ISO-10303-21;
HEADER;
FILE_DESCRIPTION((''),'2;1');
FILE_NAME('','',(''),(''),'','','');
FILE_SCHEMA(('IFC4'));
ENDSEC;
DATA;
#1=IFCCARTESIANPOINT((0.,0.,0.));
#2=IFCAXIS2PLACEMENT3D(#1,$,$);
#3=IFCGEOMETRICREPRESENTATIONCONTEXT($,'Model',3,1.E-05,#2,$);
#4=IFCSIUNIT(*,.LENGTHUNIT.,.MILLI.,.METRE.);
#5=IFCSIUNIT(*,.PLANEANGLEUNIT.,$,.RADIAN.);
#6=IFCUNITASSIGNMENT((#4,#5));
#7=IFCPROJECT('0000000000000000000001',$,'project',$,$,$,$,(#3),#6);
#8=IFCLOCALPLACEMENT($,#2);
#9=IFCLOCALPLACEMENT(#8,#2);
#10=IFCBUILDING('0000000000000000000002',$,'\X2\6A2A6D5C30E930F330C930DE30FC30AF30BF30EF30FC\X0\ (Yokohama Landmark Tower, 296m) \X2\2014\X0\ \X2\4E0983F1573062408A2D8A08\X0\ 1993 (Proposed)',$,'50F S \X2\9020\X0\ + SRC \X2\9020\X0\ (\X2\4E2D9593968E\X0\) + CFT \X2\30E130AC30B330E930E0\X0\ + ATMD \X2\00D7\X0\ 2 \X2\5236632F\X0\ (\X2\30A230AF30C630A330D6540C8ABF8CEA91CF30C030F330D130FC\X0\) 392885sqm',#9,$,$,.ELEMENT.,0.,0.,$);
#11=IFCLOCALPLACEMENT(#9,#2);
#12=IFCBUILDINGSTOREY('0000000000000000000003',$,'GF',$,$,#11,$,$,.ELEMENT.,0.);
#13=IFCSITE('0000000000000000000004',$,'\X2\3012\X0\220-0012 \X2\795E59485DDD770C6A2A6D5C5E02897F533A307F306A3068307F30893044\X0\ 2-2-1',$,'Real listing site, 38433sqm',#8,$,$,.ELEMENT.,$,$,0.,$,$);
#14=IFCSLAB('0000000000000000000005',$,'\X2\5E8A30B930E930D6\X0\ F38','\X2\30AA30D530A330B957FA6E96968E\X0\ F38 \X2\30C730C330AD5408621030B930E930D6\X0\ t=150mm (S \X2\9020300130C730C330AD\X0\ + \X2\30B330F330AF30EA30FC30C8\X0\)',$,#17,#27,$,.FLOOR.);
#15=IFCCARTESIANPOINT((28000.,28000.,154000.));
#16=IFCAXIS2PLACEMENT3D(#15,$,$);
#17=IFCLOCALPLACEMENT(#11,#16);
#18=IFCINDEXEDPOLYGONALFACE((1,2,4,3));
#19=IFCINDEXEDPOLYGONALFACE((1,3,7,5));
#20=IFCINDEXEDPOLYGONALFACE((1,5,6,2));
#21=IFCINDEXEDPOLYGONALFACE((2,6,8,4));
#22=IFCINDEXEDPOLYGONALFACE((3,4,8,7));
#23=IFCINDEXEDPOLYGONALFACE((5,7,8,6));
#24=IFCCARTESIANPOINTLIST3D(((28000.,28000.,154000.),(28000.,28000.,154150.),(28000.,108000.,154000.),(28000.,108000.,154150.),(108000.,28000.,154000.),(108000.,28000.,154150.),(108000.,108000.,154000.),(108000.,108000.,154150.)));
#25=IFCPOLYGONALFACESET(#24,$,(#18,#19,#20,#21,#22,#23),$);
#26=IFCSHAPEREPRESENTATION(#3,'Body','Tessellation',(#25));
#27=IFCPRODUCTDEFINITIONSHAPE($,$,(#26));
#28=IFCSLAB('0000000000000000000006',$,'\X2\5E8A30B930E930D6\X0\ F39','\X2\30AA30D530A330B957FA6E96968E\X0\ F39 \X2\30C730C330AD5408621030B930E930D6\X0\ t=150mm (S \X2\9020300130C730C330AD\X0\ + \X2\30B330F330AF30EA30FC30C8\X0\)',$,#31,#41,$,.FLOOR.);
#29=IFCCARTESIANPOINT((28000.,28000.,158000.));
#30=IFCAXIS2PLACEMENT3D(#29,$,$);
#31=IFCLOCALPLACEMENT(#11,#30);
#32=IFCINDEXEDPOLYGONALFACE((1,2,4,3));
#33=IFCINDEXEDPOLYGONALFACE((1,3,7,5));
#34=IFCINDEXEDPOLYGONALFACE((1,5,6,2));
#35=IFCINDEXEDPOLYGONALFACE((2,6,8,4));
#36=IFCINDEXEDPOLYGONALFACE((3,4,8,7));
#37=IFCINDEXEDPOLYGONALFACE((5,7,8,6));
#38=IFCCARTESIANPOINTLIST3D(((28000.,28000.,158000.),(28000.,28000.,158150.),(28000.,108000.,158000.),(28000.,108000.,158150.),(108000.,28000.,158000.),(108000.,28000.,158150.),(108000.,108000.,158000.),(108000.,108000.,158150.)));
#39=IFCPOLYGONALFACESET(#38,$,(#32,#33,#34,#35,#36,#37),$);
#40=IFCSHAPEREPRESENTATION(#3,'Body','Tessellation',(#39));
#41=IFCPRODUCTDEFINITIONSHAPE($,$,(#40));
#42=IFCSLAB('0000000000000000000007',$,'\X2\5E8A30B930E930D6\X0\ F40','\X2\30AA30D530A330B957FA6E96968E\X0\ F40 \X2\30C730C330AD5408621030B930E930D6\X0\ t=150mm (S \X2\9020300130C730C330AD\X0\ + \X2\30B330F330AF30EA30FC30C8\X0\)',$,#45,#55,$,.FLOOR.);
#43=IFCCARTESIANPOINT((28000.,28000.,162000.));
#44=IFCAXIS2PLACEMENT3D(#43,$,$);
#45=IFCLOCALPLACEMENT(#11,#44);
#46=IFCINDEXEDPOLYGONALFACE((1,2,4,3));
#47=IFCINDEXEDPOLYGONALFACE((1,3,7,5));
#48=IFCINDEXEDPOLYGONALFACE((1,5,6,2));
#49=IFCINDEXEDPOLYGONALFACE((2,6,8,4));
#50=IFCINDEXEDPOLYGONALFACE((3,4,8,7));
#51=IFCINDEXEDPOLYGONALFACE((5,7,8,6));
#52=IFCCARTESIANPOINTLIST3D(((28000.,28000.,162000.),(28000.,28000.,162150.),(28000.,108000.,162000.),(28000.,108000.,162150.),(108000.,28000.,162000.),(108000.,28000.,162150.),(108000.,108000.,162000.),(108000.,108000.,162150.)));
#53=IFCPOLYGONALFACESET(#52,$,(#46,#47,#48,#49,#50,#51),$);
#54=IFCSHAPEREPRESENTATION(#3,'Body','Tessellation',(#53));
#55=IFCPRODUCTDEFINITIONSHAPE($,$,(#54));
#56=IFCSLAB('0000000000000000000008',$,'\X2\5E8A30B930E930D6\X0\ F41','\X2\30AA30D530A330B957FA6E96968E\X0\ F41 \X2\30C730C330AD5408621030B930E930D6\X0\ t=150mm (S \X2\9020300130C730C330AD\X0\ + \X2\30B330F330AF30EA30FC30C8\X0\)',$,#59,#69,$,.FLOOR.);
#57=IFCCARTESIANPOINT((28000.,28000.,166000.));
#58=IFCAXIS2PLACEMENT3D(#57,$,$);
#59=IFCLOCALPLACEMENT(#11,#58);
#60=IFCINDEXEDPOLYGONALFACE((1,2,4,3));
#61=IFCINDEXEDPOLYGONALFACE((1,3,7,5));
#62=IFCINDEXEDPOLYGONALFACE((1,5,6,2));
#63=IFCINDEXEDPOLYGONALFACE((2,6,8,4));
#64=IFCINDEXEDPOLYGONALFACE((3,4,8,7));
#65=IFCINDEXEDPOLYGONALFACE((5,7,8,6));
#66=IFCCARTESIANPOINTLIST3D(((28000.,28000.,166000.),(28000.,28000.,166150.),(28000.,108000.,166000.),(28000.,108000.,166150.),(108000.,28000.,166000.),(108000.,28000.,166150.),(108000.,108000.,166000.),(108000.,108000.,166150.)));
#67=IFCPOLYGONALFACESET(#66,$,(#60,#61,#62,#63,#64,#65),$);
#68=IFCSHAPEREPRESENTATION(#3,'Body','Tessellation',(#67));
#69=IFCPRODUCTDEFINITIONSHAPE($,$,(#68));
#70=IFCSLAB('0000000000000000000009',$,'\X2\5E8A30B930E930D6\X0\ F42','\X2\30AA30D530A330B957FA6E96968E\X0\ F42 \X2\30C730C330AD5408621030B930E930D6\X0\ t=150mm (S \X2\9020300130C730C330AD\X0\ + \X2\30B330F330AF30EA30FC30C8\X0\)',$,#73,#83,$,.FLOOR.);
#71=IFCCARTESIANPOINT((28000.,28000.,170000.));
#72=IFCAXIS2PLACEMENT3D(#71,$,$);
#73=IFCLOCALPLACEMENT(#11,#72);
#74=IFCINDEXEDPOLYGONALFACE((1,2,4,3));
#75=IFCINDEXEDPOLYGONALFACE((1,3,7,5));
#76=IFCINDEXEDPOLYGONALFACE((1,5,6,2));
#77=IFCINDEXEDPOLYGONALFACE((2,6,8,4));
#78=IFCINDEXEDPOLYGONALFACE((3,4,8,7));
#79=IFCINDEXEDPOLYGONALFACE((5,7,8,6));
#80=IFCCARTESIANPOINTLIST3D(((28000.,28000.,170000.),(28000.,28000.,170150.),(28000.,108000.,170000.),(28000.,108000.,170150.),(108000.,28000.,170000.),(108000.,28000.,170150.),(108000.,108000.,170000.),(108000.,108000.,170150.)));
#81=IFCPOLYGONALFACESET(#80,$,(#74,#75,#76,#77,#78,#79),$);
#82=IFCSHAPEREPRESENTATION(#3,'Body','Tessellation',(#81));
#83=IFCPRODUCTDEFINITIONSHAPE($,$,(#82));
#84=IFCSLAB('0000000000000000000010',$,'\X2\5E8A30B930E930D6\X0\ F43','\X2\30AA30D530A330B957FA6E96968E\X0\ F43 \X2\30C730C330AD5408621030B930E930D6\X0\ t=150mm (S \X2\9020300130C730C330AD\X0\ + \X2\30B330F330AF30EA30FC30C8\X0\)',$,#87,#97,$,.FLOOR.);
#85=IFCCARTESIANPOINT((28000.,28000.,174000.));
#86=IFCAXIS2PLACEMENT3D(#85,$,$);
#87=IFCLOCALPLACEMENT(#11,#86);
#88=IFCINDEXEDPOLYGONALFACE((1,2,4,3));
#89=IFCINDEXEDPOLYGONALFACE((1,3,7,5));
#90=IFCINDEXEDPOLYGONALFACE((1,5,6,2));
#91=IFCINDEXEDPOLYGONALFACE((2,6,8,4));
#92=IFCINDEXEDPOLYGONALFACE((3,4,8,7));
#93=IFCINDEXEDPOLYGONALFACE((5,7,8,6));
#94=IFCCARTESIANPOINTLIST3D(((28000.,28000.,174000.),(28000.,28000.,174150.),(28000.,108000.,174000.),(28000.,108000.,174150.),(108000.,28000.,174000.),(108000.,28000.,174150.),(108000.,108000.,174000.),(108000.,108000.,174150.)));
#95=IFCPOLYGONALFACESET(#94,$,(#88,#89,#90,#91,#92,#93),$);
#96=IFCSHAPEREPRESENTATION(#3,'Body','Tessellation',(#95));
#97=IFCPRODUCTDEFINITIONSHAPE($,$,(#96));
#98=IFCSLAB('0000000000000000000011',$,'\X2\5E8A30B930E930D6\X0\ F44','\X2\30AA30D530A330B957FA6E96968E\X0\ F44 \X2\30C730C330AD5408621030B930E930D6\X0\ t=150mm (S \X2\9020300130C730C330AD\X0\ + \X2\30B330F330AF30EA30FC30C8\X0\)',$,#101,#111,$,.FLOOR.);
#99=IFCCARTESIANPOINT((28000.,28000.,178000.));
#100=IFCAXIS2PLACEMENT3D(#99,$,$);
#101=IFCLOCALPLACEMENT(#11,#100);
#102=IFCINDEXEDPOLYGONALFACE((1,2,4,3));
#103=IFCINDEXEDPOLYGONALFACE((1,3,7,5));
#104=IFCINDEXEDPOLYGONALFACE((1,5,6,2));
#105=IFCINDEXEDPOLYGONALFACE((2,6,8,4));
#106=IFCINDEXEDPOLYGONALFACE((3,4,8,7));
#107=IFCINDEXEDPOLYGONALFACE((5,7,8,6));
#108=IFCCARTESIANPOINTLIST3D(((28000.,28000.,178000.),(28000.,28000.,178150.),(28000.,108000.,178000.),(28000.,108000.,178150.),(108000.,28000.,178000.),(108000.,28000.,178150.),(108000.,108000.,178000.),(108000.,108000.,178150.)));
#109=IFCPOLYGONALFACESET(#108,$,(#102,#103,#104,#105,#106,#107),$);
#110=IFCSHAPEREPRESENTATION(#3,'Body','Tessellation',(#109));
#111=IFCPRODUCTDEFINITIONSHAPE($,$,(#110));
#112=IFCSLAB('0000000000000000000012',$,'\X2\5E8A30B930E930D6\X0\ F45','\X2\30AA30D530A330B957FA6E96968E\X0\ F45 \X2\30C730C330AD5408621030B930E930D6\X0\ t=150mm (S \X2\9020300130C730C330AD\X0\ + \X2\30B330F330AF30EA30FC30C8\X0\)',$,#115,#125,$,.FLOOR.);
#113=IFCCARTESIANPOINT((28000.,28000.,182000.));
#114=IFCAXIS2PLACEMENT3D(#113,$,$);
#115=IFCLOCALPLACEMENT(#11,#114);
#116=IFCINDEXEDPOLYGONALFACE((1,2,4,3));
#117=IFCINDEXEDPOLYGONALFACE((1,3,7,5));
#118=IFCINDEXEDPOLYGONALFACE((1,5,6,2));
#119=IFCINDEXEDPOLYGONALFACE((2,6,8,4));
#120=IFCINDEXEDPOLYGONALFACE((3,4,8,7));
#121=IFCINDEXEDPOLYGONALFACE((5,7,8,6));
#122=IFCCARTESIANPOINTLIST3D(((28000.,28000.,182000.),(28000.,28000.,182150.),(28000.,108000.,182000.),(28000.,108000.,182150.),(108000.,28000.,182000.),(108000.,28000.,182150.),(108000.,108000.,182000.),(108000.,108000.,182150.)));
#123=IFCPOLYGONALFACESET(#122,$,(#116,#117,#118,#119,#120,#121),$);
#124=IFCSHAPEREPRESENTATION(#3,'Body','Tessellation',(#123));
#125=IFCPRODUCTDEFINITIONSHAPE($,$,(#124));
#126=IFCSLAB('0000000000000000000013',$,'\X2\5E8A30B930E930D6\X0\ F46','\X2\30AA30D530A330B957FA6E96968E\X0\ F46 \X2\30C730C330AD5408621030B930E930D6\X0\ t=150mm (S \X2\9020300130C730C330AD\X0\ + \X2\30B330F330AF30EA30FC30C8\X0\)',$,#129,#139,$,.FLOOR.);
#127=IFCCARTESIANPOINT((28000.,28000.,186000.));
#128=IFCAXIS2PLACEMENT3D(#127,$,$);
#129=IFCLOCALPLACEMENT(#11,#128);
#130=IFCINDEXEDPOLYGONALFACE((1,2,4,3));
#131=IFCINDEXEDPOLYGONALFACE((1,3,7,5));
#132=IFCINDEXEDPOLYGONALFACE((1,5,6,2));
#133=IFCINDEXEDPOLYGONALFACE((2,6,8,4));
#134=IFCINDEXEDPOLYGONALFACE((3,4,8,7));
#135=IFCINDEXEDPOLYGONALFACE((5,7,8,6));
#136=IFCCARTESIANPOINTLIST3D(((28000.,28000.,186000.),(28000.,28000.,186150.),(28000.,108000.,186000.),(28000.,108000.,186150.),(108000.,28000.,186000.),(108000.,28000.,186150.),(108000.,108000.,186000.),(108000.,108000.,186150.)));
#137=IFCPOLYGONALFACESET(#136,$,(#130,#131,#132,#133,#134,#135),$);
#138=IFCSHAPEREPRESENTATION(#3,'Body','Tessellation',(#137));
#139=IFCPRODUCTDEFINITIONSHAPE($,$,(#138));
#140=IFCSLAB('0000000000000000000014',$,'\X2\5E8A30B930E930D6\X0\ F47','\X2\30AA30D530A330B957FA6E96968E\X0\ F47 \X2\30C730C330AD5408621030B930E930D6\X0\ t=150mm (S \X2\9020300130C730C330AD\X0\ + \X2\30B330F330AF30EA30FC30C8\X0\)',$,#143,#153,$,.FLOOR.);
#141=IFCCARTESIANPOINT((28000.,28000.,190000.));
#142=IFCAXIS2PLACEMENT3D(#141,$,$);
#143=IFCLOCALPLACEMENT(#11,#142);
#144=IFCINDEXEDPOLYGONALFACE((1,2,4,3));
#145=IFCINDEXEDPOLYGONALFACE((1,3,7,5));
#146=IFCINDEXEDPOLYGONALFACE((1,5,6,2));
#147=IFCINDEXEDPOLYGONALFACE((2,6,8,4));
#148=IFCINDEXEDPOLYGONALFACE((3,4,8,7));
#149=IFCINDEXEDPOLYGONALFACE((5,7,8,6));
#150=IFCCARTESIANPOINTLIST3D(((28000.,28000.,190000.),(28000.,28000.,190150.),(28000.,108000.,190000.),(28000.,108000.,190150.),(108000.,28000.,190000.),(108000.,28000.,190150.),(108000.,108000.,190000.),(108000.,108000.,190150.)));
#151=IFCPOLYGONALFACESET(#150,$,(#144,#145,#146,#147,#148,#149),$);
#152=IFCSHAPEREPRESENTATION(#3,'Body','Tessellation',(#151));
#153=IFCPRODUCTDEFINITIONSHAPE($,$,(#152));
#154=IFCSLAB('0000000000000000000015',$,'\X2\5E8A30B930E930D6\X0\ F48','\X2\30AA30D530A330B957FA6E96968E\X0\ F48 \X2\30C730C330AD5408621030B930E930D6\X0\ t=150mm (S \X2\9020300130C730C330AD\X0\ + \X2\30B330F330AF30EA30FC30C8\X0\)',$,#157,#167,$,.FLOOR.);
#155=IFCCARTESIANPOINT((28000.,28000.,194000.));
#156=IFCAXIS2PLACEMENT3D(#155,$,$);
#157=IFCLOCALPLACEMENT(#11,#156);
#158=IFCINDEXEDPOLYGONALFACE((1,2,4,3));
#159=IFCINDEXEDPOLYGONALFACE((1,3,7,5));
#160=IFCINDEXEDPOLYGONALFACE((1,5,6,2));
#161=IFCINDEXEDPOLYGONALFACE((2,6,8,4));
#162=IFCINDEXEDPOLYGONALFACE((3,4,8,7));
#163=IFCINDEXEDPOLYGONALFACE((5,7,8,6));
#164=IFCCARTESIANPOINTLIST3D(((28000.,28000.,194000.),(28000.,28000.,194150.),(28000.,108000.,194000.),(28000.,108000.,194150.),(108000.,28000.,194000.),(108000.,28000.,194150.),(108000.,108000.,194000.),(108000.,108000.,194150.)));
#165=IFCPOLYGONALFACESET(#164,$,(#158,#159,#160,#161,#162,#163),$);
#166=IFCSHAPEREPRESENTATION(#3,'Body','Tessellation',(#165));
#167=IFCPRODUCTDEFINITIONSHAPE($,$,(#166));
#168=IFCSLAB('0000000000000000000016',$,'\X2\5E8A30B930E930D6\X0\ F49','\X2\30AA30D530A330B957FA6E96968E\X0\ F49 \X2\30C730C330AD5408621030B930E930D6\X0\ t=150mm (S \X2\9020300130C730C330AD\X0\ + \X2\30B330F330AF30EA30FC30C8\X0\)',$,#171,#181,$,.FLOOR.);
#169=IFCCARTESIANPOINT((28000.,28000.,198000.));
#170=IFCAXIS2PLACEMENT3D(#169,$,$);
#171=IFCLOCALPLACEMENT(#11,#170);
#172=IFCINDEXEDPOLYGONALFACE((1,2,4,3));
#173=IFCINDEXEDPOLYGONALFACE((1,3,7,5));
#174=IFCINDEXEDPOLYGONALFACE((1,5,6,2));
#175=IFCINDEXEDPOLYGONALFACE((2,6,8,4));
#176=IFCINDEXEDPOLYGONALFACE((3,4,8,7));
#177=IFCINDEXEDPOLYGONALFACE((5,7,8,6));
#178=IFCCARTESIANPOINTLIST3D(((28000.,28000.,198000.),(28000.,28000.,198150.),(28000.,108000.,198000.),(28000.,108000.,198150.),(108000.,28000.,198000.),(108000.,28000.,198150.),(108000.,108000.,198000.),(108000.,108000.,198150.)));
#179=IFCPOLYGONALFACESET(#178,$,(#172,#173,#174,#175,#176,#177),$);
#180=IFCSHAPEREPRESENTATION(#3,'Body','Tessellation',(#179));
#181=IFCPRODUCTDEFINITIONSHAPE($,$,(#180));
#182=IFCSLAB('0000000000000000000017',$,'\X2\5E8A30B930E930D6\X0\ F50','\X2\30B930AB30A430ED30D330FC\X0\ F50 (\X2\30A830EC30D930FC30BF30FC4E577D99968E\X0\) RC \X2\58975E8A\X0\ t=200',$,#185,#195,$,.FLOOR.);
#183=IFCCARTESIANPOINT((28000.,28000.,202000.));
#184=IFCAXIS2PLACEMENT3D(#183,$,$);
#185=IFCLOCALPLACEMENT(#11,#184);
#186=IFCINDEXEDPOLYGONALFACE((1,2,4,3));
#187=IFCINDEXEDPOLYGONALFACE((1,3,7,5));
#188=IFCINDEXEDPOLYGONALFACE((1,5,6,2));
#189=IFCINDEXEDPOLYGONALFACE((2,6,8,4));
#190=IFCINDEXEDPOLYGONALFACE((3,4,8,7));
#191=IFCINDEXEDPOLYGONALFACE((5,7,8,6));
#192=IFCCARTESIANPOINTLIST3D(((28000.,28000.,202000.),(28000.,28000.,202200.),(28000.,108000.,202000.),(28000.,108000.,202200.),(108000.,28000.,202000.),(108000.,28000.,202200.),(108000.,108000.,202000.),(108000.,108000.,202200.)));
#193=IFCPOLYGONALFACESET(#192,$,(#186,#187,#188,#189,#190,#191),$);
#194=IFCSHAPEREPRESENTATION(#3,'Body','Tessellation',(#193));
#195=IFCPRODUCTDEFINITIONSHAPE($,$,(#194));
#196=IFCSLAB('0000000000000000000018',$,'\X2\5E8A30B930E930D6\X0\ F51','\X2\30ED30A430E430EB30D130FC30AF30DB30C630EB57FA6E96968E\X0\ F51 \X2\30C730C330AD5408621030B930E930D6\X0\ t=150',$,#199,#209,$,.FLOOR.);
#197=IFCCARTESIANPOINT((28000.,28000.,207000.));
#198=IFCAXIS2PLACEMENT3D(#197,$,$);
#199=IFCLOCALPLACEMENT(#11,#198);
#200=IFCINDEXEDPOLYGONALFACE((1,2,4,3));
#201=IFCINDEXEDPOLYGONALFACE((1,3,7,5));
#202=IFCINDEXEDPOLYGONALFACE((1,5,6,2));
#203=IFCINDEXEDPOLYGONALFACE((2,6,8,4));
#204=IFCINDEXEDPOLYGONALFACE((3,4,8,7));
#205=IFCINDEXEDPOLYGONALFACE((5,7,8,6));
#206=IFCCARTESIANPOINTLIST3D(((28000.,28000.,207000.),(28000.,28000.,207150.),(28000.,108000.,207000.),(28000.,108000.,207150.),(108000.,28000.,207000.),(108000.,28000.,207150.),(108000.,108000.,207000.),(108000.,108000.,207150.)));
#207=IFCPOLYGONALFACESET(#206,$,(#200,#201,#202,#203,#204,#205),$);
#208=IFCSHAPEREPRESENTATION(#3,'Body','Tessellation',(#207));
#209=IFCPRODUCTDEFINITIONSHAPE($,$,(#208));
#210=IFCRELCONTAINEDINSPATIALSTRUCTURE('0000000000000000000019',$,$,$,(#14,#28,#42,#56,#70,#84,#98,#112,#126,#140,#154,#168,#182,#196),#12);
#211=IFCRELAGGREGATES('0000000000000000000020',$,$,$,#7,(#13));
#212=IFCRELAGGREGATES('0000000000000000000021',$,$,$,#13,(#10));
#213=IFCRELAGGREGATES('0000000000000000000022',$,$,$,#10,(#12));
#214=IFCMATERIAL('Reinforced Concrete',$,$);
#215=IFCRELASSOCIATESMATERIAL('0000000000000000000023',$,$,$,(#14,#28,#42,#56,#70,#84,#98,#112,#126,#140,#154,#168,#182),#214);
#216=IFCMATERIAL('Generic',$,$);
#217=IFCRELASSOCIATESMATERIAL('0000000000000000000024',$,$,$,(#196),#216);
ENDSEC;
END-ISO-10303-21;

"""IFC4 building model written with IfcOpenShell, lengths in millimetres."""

from ifc_helpers import new_model, si_unit, frame, frame_2d, origin, place, context, project, spatial, rectangle, extrude, material, element, save


model = new_model("IFC4")

# Units and contexts
model_context = context("Model", 3, precision=1e-05, world=origin())
ifc_project = project(units=[si_unit("LENGTHUNIT", "METRE", prefix="MILLI"), si_unit("PLANEANGLEUNIT", "RADIAN")], contexts=[model_context])

# Site, building, storey
site_placement = place(None, origin())
site = spatial("IfcSite", under=ifc_project, at=site_placement, Name="〒220-0012 神奈川県横浜市西区みなとみらい 2-2-1", ObjectType="Real listing site, 38433sqm", CompositionType="ELEMENT", RefElevation=0.0)
building_placement = place(site_placement, origin())
building = spatial("IfcBuilding", under=site, at=building_placement, Name="横浜ランドマークタワー (Yokohama Landmark Tower, 296m) — 三菱地所設計 1993 (Proposed)", ObjectType="50F S 造 + SRC 造 (中間階) + CFT メガコラム + ATMD × 2 制振 (アクティブ同調質量ダンパー) 392885sqm", CompositionType="ELEMENT", ElevationOfRefHeight=0.0, ElevationOfTerrain=0.0)
storey_placement = place(building_placement, origin())
storey = spatial("IfcBuildingStorey", under=building, at=storey_placement, Name="GF", CompositionType="ELEMENT", Elevation=0.0)

# Shared definitions
ifc_material_1 = material(Name="Reinforced Concrete")

# Slabs
slab_1_placement = place(storey_placement, frame((28000.0, 28000.0, 154000.0)))
element("IfcSlab", 1, at=slab_1_placement, inside=storey, material=ifc_material_1, Name="床スラブ F38", Description="オフィス基準階 F38 デッキ合成スラブ t=150mm (S 造、デッキ + コンクリート)", PredefinedType="FLOOR", context=model_context, shape_type="SweptSolid", body=[
    extrude(rectangle(XDim=80000.0, YDim=80000.0, at=frame_2d((40000.0, 40000.0))), frame((28000.0, 28000.0, 154000.0)), (0.0, 0.0, 1.0), 150.0),
])
slab_2_placement = place(storey_placement, frame((28000.0, 28000.0, 158000.0)))
element("IfcSlab", 2, at=slab_2_placement, inside=storey, material=ifc_material_1, Name="床スラブ F39", Description="オフィス基準階 F39 デッキ合成スラブ t=150mm (S 造、デッキ + コンクリート)", PredefinedType="FLOOR", context=model_context, shape_type="SweptSolid", body=[
    extrude(rectangle(XDim=80000.0, YDim=80000.0, at=frame_2d((40000.0, 40000.0))), frame((28000.0, 28000.0, 158000.0)), (0.0, 0.0, 1.0), 150.0),
])
slab_3_placement = place(storey_placement, frame((28000.0, 28000.0, 162000.0)))
element("IfcSlab", 3, at=slab_3_placement, inside=storey, material=ifc_material_1, Name="床スラブ F40", Description="オフィス基準階 F40 デッキ合成スラブ t=150mm (S 造、デッキ + コンクリート)", PredefinedType="FLOOR", context=model_context, shape_type="SweptSolid", body=[
    extrude(rectangle(XDim=80000.0, YDim=80000.0, at=frame_2d((40000.0, 40000.0))), frame((28000.0, 28000.0, 162000.0)), (0.0, 0.0, 1.0), 150.0),
])
slab_4_placement = place(storey_placement, frame((28000.0, 28000.0, 166000.0)))
element("IfcSlab", 4, at=slab_4_placement, inside=storey, material=ifc_material_1, Name="床スラブ F41", Description="オフィス基準階 F41 デッキ合成スラブ t=150mm (S 造、デッキ + コンクリート)", PredefinedType="FLOOR", context=model_context, shape_type="SweptSolid", body=[
    extrude(rectangle(XDim=80000.0, YDim=80000.0, at=frame_2d((40000.0, 40000.0))), frame((28000.0, 28000.0, 166000.0)), (0.0, 0.0, 1.0), 150.0),
])
slab_5_placement = place(storey_placement, frame((28000.0, 28000.0, 170000.0)))
element("IfcSlab", 5, at=slab_5_placement, inside=storey, material=ifc_material_1, Name="床スラブ F42", Description="オフィス基準階 F42 デッキ合成スラブ t=150mm (S 造、デッキ + コンクリート)", PredefinedType="FLOOR", context=model_context, shape_type="SweptSolid", body=[
    extrude(rectangle(XDim=80000.0, YDim=80000.0, at=frame_2d((40000.0, 40000.0))), frame((28000.0, 28000.0, 170000.0)), (0.0, 0.0, 1.0), 150.0),
])
slab_6_placement = place(storey_placement, frame((28000.0, 28000.0, 174000.0)))
element("IfcSlab", 6, at=slab_6_placement, inside=storey, material=ifc_material_1, Name="床スラブ F43", Description="オフィス基準階 F43 デッキ合成スラブ t=150mm (S 造、デッキ + コンクリート)", PredefinedType="FLOOR", context=model_context, shape_type="SweptSolid", body=[
    extrude(rectangle(XDim=80000.0, YDim=80000.0, at=frame_2d((40000.0, 40000.0))), frame((28000.0, 28000.0, 174000.0)), (0.0, 0.0, 1.0), 150.0),
])
slab_7_placement = place(storey_placement, frame((28000.0, 28000.0, 178000.0)))
element("IfcSlab", 7, at=slab_7_placement, inside=storey, material=ifc_material_1, Name="床スラブ F44", Description="オフィス基準階 F44 デッキ合成スラブ t=150mm (S 造、デッキ + コンクリート)", PredefinedType="FLOOR", context=model_context, shape_type="SweptSolid", body=[
    extrude(rectangle(XDim=80000.0, YDim=80000.0, at=frame_2d((40000.0, 40000.0))), frame((28000.0, 28000.0, 178000.0)), (0.0, 0.0, 1.0), 150.0),
])
slab_8_placement = place(storey_placement, frame((28000.0, 28000.0, 182000.0)))
element("IfcSlab", 8, at=slab_8_placement, inside=storey, material=ifc_material_1, Name="床スラブ F45", Description="オフィス基準階 F45 デッキ合成スラブ t=150mm (S 造、デッキ + コンクリート)", PredefinedType="FLOOR", context=model_context, shape_type="SweptSolid", body=[
    extrude(rectangle(XDim=80000.0, YDim=80000.0, at=frame_2d((40000.0, 40000.0))), frame((28000.0, 28000.0, 182000.0)), (0.0, 0.0, 1.0), 150.0),
])
slab_9_placement = place(storey_placement, frame((28000.0, 28000.0, 186000.0)))
element("IfcSlab", 9, at=slab_9_placement, inside=storey, material=ifc_material_1, Name="床スラブ F46", Description="オフィス基準階 F46 デッキ合成スラブ t=150mm (S 造、デッキ + コンクリート)", PredefinedType="FLOOR", context=model_context, shape_type="SweptSolid", body=[
    extrude(rectangle(XDim=80000.0, YDim=80000.0, at=frame_2d((40000.0, 40000.0))), frame((28000.0, 28000.0, 186000.0)), (0.0, 0.0, 1.0), 150.0),
])
slab_10_placement = place(storey_placement, frame((28000.0, 28000.0, 190000.0)))
element("IfcSlab", 10, at=slab_10_placement, inside=storey, material=ifc_material_1, Name="床スラブ F47", Description="オフィス基準階 F47 デッキ合成スラブ t=150mm (S 造、デッキ + コンクリート)", PredefinedType="FLOOR", context=model_context, shape_type="SweptSolid", body=[
    extrude(rectangle(XDim=80000.0, YDim=80000.0, at=frame_2d((40000.0, 40000.0))), frame((28000.0, 28000.0, 190000.0)), (0.0, 0.0, 1.0), 150.0),
])
slab_11_placement = place(storey_placement, frame((28000.0, 28000.0, 194000.0)))
element("IfcSlab", 11, at=slab_11_placement, inside=storey, material=ifc_material_1, Name="床スラブ F48", Description="オフィス基準階 F48 デッキ合成スラブ t=150mm (S 造、デッキ + コンクリート)", PredefinedType="FLOOR", context=model_context, shape_type="SweptSolid", body=[
    extrude(rectangle(XDim=80000.0, YDim=80000.0, at=frame_2d((40000.0, 40000.0))), frame((28000.0, 28000.0, 194000.0)), (0.0, 0.0, 1.0), 150.0),
])
slab_12_placement = place(storey_placement, frame((28000.0, 28000.0, 198000.0)))
element("IfcSlab", 12, at=slab_12_placement, inside=storey, material=ifc_material_1, Name="床スラブ F49", Description="オフィス基準階 F49 デッキ合成スラブ t=150mm (S 造、デッキ + コンクリート)", PredefinedType="FLOOR", context=model_context, shape_type="SweptSolid", body=[
    extrude(rectangle(XDim=80000.0, YDim=80000.0, at=frame_2d((40000.0, 40000.0))), frame((28000.0, 28000.0, 198000.0)), (0.0, 0.0, 1.0), 150.0),
])
slab_13_placement = place(storey_placement, frame((28000.0, 28000.0, 202000.0)))
element("IfcSlab", 13, at=slab_13_placement, inside=storey, material=ifc_material_1, Name="床スラブ F50", Description="スカイロビー F50 (エレベーター乗継階) RC 増床 t=200", PredefinedType="FLOOR", context=model_context, shape_type="SweptSolid", body=[
    extrude(rectangle(XDim=80000.0, YDim=80000.0, at=frame_2d((40000.0, 40000.0))), frame((28000.0, 28000.0, 202000.0)), (0.0, 0.0, 1.0), 200.0),
])
ifc_material_2 = material(Name="Generic")
slab_14_placement = place(storey_placement, frame((28000.0, 28000.0, 207000.0)))
element("IfcSlab", 14, at=slab_14_placement, inside=storey, material=ifc_material_2, Name="床スラブ F51", Description="ロイヤルパークホテル基準階 F51 デッキ合成スラブ t=150", PredefinedType="FLOOR", context=model_context, shape_type="SweptSolid", body=[
    extrude(rectangle(XDim=80000.0, YDim=80000.0, at=frame_2d((40000.0, 40000.0))), frame((28000.0, 28000.0, 207000.0)), (0.0, 0.0, 1.0), 150.0),
])

save(model, "model.ifc")
